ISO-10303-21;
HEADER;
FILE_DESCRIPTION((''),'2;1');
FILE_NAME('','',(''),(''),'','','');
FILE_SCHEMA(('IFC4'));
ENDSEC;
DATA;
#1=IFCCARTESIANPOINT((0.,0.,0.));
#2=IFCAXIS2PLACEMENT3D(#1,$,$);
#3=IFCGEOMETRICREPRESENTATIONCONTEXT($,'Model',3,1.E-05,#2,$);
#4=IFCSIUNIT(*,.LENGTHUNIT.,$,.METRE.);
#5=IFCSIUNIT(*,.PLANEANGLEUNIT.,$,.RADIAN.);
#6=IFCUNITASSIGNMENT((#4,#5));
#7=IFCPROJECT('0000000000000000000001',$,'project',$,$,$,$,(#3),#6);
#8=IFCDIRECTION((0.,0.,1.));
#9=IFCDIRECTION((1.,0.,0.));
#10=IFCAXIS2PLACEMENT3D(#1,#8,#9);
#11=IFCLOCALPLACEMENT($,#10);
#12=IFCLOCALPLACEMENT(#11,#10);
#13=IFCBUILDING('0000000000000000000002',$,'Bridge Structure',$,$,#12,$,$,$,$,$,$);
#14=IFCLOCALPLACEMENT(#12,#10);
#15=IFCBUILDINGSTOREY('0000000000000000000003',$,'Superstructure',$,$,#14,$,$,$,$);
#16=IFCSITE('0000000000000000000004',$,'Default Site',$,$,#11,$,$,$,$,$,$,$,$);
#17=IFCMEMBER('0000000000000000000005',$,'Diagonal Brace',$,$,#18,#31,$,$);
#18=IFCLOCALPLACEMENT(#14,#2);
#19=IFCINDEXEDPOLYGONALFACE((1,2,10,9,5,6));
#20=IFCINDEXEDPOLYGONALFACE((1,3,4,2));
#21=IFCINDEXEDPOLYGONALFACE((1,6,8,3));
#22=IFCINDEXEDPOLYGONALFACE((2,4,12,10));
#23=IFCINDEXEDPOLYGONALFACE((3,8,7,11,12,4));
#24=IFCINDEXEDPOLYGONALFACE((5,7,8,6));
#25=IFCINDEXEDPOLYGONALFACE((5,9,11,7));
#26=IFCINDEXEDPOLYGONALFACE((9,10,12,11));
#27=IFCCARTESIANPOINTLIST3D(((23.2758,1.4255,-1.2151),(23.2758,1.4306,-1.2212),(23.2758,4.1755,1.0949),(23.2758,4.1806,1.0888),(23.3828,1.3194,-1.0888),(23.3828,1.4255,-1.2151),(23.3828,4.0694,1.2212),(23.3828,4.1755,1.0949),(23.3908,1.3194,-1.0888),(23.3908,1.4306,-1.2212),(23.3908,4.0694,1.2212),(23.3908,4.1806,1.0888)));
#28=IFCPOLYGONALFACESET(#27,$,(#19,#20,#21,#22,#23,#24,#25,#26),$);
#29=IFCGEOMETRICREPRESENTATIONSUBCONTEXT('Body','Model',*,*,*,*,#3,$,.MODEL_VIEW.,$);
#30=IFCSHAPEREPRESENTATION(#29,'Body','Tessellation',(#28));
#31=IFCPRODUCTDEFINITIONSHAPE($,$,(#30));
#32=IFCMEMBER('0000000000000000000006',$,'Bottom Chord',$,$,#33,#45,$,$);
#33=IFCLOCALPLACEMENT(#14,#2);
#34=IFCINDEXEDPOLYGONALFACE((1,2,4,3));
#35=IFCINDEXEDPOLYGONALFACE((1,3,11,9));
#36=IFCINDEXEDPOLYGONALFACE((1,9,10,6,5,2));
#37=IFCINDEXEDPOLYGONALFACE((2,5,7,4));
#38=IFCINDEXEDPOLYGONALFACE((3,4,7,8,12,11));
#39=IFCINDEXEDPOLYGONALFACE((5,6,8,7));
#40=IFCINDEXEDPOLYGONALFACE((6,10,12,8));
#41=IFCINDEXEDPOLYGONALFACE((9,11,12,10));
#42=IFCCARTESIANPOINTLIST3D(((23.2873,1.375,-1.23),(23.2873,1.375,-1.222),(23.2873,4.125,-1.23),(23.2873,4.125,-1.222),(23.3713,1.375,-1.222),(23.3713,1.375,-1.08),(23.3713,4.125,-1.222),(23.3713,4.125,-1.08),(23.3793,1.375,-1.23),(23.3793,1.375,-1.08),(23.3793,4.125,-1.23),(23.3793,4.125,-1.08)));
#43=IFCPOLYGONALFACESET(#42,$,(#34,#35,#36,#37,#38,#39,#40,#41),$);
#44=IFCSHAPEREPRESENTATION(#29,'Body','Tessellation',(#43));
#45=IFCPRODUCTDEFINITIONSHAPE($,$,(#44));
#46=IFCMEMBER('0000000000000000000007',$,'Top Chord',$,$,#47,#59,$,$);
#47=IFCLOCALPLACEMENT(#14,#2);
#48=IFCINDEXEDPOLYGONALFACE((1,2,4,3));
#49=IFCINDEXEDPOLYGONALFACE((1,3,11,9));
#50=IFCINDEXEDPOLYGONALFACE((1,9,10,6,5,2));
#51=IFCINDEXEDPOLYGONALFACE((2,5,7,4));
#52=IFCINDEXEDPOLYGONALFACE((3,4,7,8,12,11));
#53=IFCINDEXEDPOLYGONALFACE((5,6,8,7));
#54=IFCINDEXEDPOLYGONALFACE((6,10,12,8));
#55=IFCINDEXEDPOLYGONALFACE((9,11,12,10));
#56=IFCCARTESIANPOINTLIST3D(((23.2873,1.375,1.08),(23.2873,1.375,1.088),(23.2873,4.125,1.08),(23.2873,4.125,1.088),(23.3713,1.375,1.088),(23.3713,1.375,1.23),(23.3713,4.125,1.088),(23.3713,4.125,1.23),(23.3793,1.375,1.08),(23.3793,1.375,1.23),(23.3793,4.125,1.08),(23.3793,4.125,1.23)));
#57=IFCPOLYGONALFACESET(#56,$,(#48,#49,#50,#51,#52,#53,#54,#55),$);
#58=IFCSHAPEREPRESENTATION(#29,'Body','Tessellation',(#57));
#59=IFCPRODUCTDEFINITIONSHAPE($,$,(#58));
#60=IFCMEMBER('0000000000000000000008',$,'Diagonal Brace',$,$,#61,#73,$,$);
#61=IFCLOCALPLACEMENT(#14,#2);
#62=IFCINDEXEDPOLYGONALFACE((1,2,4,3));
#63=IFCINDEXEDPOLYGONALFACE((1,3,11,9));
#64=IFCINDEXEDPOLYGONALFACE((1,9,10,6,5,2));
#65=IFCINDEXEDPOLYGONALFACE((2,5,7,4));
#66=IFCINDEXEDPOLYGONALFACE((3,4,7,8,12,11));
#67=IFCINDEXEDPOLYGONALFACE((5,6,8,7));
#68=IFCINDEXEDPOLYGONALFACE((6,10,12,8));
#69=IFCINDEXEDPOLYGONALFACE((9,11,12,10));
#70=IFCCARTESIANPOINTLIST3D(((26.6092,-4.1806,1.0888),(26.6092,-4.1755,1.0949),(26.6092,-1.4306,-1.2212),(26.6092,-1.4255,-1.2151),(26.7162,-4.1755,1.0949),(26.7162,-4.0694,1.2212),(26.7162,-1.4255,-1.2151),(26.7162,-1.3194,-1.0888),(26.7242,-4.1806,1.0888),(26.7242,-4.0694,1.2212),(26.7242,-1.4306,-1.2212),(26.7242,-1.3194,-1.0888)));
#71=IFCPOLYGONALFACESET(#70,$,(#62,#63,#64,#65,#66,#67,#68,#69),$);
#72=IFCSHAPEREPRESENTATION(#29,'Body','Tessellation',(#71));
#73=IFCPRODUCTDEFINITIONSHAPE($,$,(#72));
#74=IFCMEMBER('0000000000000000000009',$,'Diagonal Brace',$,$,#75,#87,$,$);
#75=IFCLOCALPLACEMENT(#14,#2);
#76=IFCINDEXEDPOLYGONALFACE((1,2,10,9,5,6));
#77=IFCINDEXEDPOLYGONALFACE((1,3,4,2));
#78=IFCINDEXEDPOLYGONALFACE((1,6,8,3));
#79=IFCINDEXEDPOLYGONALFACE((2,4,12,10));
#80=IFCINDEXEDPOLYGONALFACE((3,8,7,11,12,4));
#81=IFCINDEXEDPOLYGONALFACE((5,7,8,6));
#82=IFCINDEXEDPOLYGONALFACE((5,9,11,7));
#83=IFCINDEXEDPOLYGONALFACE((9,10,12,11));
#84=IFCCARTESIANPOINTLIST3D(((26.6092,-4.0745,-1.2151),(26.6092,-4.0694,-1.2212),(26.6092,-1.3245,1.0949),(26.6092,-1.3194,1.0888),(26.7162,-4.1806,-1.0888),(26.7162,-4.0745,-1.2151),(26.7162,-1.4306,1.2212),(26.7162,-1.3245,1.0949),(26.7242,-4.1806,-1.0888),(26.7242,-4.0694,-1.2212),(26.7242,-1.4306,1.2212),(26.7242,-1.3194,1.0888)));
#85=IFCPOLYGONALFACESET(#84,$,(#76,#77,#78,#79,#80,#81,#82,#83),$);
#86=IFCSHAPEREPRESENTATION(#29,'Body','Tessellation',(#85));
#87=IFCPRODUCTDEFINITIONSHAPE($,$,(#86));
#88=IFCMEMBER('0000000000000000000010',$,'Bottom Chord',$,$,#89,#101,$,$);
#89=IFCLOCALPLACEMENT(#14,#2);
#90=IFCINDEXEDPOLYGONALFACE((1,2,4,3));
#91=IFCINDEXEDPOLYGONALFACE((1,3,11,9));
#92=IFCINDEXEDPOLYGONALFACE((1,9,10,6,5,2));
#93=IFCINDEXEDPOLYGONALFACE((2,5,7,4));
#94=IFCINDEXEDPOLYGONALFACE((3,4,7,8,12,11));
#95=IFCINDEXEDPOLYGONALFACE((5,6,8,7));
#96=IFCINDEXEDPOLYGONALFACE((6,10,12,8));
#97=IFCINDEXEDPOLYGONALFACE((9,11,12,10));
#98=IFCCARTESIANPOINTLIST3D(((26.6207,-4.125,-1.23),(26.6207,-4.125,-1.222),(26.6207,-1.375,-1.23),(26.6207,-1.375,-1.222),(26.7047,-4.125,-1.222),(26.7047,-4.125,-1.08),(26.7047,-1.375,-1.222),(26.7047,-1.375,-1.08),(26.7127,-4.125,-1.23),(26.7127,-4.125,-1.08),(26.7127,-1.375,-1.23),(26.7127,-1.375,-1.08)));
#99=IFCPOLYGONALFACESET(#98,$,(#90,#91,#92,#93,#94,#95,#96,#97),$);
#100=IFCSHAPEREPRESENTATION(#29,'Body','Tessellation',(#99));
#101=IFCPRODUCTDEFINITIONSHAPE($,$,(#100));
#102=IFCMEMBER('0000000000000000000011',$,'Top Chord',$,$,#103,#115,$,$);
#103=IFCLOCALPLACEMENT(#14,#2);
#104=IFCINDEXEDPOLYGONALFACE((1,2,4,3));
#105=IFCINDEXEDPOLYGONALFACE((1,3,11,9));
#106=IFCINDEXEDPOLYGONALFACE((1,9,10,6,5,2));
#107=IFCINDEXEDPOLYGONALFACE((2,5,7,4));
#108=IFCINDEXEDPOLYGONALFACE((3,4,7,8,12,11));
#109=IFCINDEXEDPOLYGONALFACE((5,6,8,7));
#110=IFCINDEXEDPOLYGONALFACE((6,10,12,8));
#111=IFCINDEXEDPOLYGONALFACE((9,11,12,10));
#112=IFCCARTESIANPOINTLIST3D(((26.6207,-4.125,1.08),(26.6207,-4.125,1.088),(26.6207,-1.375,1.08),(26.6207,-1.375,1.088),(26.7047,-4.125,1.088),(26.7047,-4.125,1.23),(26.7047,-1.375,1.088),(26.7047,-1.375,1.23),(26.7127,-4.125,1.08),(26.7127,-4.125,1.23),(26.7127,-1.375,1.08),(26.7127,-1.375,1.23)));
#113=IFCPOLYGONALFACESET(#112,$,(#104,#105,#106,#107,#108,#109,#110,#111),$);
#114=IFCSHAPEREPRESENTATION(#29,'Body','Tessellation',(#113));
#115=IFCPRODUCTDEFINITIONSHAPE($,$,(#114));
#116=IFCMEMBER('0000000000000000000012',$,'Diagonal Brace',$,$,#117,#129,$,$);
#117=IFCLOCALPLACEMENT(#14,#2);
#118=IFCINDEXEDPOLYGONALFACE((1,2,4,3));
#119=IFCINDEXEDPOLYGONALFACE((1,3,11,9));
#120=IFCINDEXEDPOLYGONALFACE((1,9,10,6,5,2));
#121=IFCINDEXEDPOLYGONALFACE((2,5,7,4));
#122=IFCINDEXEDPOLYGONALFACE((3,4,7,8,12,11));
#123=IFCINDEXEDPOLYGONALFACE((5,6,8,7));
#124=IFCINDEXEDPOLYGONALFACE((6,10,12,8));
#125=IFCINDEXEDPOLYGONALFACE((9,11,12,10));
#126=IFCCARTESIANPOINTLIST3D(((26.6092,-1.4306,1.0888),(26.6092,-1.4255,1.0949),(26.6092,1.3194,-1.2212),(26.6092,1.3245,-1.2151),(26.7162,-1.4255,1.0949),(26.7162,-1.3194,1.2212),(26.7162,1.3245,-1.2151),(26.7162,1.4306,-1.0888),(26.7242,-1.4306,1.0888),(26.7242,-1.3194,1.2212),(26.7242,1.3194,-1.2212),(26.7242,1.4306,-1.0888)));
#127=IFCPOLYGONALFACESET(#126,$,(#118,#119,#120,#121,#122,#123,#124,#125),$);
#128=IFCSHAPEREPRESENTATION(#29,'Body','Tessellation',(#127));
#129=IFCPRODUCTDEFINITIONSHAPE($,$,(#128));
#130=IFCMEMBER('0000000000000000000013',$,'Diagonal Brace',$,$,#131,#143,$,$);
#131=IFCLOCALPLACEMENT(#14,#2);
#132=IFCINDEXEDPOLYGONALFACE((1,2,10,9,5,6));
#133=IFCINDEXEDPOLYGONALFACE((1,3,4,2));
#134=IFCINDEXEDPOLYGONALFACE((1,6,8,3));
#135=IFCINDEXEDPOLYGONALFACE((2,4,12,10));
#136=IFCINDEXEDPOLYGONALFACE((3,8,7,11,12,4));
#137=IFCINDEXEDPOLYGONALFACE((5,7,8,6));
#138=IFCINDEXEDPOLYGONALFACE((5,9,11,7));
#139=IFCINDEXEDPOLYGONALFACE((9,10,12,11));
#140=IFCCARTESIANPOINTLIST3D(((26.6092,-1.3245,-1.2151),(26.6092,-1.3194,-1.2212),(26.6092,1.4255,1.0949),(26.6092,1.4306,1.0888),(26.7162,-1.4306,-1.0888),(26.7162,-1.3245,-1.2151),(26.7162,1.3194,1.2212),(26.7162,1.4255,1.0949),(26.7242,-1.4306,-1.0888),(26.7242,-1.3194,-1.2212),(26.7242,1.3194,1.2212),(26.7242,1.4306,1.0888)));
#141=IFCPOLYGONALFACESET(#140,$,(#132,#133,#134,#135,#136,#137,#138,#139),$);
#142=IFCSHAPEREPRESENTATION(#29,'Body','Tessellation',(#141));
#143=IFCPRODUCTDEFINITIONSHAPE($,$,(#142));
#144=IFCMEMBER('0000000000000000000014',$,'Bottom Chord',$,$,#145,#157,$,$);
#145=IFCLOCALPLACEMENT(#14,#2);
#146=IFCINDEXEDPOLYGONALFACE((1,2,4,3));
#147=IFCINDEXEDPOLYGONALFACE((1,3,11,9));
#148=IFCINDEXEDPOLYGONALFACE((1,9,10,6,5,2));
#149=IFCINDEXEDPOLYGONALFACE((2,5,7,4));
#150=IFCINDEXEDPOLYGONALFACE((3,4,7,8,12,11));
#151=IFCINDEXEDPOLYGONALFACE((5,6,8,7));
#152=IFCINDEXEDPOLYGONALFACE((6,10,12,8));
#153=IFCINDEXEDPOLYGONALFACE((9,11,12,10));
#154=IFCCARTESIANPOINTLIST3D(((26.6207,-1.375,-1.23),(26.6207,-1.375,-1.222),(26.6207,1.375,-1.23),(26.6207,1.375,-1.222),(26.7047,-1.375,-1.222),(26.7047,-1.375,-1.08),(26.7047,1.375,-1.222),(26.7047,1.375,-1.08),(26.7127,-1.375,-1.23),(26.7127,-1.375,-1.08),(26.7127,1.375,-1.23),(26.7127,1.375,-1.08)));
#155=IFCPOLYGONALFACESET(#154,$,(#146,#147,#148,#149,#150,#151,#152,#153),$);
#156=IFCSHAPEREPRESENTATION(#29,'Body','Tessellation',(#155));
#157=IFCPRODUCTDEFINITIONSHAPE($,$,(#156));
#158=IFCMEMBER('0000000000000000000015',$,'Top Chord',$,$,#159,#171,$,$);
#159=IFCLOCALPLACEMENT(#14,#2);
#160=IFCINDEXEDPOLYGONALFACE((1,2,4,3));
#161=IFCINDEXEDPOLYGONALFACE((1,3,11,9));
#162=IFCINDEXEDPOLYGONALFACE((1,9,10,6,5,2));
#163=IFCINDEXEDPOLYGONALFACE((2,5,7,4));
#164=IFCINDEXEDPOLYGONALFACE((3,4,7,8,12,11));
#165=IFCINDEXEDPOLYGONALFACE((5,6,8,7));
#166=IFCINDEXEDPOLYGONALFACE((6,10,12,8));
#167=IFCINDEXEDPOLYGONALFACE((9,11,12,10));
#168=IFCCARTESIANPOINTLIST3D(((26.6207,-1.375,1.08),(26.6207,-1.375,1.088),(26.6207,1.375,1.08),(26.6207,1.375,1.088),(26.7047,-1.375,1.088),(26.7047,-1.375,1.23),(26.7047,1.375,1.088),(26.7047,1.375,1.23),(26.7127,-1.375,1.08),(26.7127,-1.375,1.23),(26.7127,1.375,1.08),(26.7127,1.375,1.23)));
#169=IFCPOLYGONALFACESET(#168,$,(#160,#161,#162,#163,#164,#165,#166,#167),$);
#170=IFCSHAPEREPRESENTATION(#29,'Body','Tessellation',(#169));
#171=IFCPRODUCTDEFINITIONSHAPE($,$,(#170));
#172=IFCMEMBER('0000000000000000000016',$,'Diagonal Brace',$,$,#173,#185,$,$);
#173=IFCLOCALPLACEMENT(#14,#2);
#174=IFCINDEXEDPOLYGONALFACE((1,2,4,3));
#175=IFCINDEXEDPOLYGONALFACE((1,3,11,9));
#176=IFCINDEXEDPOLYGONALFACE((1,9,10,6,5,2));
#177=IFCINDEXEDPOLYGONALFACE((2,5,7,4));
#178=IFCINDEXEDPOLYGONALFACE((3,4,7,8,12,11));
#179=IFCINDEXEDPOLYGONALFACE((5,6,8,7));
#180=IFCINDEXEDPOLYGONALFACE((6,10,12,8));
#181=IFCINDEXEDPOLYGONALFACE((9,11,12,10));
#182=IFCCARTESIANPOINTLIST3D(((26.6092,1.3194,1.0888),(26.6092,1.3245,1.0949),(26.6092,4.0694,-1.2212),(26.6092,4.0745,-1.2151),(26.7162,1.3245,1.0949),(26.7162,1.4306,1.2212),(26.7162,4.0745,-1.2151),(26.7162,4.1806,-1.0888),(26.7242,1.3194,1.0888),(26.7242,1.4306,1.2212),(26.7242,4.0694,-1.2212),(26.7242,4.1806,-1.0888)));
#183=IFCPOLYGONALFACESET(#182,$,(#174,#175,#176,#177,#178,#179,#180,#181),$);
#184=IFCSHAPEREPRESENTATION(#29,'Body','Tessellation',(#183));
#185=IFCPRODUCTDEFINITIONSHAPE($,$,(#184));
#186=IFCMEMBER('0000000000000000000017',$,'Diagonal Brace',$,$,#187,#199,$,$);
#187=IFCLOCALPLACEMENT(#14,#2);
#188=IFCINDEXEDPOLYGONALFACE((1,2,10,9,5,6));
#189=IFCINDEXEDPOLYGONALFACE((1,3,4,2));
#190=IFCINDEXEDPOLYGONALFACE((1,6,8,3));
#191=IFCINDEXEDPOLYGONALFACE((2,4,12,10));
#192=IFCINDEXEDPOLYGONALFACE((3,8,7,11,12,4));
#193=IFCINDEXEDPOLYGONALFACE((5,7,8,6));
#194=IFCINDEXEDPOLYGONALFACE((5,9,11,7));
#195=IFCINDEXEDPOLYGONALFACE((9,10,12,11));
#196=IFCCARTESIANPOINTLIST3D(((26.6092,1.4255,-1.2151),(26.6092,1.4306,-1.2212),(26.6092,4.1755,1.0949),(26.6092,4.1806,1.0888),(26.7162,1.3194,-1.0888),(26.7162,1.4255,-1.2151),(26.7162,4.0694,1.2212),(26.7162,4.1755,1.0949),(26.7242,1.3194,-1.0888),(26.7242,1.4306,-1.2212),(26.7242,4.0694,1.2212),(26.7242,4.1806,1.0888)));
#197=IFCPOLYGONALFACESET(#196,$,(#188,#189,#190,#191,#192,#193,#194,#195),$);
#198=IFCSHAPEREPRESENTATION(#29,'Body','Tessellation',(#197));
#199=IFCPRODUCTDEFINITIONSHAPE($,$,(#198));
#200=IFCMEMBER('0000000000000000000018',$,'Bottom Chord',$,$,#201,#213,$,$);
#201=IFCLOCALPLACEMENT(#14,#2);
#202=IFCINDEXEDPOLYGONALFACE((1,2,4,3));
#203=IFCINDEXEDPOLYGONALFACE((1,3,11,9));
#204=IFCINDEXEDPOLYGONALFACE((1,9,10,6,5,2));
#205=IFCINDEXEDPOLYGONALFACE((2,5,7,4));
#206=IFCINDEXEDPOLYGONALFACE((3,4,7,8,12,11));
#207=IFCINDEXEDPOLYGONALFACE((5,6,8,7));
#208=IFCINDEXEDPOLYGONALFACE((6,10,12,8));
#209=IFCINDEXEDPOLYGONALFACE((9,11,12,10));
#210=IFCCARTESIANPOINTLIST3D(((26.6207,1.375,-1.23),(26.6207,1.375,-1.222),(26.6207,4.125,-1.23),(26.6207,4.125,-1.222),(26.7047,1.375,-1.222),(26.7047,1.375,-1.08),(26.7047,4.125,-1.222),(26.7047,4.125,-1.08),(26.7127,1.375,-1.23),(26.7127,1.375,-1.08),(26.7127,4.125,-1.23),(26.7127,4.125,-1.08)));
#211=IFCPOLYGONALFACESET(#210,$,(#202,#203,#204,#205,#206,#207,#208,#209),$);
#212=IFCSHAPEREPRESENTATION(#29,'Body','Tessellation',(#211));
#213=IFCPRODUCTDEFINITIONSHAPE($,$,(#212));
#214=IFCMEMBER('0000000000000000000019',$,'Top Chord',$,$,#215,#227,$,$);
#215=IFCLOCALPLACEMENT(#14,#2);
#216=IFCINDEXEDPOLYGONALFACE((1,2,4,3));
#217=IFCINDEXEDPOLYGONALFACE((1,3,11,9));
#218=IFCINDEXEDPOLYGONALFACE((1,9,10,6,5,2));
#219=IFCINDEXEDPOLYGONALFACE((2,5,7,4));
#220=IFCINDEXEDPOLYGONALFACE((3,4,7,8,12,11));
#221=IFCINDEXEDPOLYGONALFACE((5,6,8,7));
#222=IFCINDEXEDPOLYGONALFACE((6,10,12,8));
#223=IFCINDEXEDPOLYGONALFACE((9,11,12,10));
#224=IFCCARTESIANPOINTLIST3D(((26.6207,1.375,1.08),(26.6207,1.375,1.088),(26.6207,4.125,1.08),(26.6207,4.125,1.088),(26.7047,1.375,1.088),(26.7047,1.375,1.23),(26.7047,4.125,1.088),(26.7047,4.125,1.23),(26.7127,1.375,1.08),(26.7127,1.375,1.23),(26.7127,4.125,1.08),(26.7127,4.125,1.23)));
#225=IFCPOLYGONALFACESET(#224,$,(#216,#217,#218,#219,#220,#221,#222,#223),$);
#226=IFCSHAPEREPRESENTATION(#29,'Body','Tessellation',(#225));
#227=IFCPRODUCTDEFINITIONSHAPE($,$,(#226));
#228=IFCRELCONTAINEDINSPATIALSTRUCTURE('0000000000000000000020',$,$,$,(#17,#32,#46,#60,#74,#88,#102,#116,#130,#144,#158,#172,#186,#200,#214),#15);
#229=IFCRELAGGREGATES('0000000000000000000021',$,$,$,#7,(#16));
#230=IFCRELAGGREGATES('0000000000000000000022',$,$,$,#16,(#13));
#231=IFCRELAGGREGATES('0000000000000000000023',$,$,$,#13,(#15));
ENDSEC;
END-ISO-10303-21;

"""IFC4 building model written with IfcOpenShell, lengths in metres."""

from ifc_helpers import new_model, si_unit, frame, origin, origin_with_axes, origin_2d_with_axis, place, context, subcontext, project, spatial, l_section, extrude, element, save


model = new_model("IFC4")

# Units and contexts
model_context = context("Model", 3, precision=1e-05, world=origin())
body_context = subcontext(model_context, "Body", "Model", "MODEL_VIEW")
ifc_project = project(units=[si_unit("LENGTHUNIT", "METRE"), si_unit("PLANEANGLEUNIT", "RADIAN")], contexts=[model_context])

# Site, building, storey
site_placement = place(None, origin_with_axes())
site = spatial("IfcSite", under=ifc_project, at=site_placement, Name="Default Site")
building_placement = place(site_placement, origin_with_axes())
building = spatial("IfcBuilding", under=site, at=building_placement, Name="Bridge Structure")
storey_placement = place(building_placement, origin_with_axes())
storey = spatial("IfcBuildingStorey", under=building, at=storey_placement, Name="Superstructure")

# Members
member_1_placement = place(storey_placement, frame((23.3333, 1.375, -1.155), z_axis=(0.0, 0.765705, 0.643192), x_axis=(-1.0, 0.0, 0.0)))
element("IfcMember", 1, at=member_1_placement, inside=storey, Name="Diagonal Brace", context=body_context, shape_type="SweptSolid", body=[
    extrude(l_section(Depth=0.173, Width=0.115, Thickness=0.008, at=origin_2d_with_axis()), origin_with_axes(), (0.0, 0.0, 1.0), 3.5915),
])
for number, where, z_axis, x_axis, name in (
    (2, (23.3333, 1.375, -1.155), (0.0, 1.0, 0.0), (-1.0, 0.0, 0.0), "Bottom Chord"),
    (3, (23.3333, 1.375, 1.155), (0.0, 1.0, 0.0), (-1.0, 0.0, 0.0), "Top Chord"),
):
    element("IfcMember", number, at=place(storey_placement, frame(where, z_axis=z_axis, x_axis=x_axis)), inside=storey, Name=name, context=body_context, shape_type="SweptSolid", body=[
        extrude(l_section(Depth=0.15, Width=0.092, Thickness=0.008, at=origin_2d_with_axis()), origin_with_axes(), (0.0, 0.0, 1.0), 2.75),
    ])
for number, where, z_axis, x_axis, name in (
    (4, (26.6667, -4.125, 1.155), (0.0, 0.765705, -0.643192), (-1.0, 0.0, 0.0), "Diagonal Brace"),
    (5, (26.6667, -4.125, -1.155), (0.0, 0.765705, 0.643192), (-1.0, 0.0, 0.0), "Diagonal Brace"),
):
    element("IfcMember", number, at=place(storey_placement, frame(where, z_axis=z_axis, x_axis=x_axis)), inside=storey, Name=name, context=body_context, shape_type="SweptSolid", body=[
        extrude(l_section(Depth=0.173, Width=0.115, Thickness=0.008, at=origin_2d_with_axis()), origin_with_axes(), (0.0, 0.0, 1.0), 3.5915),
    ])
for number, where, z_axis, x_axis, name in (
    (6, (26.6667, -4.125, -1.155), (0.0, 1.0, 0.0), (-1.0, 0.0, 0.0), "Bottom Chord"),
    (7, (26.6667, -4.125, 1.155), (0.0, 1.0, 0.0), (-1.0, 0.0, 0.0), "Top Chord"),
):
    element("IfcMember", number, at=place(storey_placement, frame(where, z_axis=z_axis, x_axis=x_axis)), inside=storey, Name=name, context=body_context, shape_type="SweptSolid", body=[
        extrude(l_section(Depth=0.15, Width=0.092, Thickness=0.008, at=origin_2d_with_axis()), origin_with_axes(), (0.0, 0.0, 1.0), 2.75),
    ])
for number, where, z_axis, x_axis, name in (
    (8, (26.6667, -1.375, 1.155), (0.0, 0.765705, -0.643192), (-1.0, 0.0, 0.0), "Diagonal Brace"),
    (9, (26.6667, -1.375, -1.155), (0.0, 0.765705, 0.643192), (-1.0, 0.0, 0.0), "Diagonal Brace"),
):
    element("IfcMember", number, at=place(storey_placement, frame(where, z_axis=z_axis, x_axis=x_axis)), inside=storey, Name=name, context=body_context, shape_type="SweptSolid", body=[
        extrude(l_section(Depth=0.173, Width=0.115, Thickness=0.008, at=origin_2d_with_axis()), origin_with_axes(), (0.0, 0.0, 1.0), 3.5915),
    ])
for number, where, z_axis, x_axis, name in (
    (10, (26.6667, -1.375, -1.155), (0.0, 1.0, 0.0), (-1.0, 0.0, 0.0), "Bottom Chord"),
    (11, (26.6667, -1.375, 1.155), (0.0, 1.0, 0.0), (-1.0, 0.0, 0.0), "Top Chord"),
):
    element("IfcMember", number, at=place(storey_placement, frame(where, z_axis=z_axis, x_axis=x_axis)), inside=storey, Name=name, context=body_context, shape_type="SweptSolid", body=[
        extrude(l_section(Depth=0.15, Width=0.092, Thickness=0.008, at=origin_2d_with_axis()), origin_with_axes(), (0.0, 0.0, 1.0), 2.75),
    ])
for number, where, z_axis, x_axis, name in (
    (12, (26.6667, 1.375, 1.155), (0.0, 0.765705, -0.643192), (-1.0, 0.0, 0.0), "Diagonal Brace"),
    (13, (26.6667, 1.375, -1.155), (0.0, 0.765705, 0.643192), (-1.0, 0.0, 0.0), "Diagonal Brace"),
):
    element("IfcMember", number, at=place(storey_placement, frame(where, z_axis=z_axis, x_axis=x_axis)), inside=storey, Name=name, context=body_context, shape_type="SweptSolid", body=[
        extrude(l_section(Depth=0.173, Width=0.115, Thickness=0.008, at=origin_2d_with_axis()), origin_with_axes(), (0.0, 0.0, 1.0), 3.5915),
    ])
for number, where, z_axis, x_axis, name in (
    (14, (26.6667, 1.375, -1.155), (0.0, 1.0, 0.0), (-1.0, 0.0, 0.0), "Bottom Chord"),
    (15, (26.6667, 1.375, 1.155), (0.0, 1.0, 0.0), (-1.0, 0.0, 0.0), "Top Chord"),
):
    element("IfcMember", number, at=place(storey_placement, frame(where, z_axis=z_axis, x_axis=x_axis)), inside=storey, Name=name, context=body_context, shape_type="SweptSolid", body=[
        extrude(l_section(Depth=0.15, Width=0.092, Thickness=0.008, at=origin_2d_with_axis()), origin_with_axes(), (0.0, 0.0, 1.0), 2.75),
    ])

save(model, "model.ifc")
